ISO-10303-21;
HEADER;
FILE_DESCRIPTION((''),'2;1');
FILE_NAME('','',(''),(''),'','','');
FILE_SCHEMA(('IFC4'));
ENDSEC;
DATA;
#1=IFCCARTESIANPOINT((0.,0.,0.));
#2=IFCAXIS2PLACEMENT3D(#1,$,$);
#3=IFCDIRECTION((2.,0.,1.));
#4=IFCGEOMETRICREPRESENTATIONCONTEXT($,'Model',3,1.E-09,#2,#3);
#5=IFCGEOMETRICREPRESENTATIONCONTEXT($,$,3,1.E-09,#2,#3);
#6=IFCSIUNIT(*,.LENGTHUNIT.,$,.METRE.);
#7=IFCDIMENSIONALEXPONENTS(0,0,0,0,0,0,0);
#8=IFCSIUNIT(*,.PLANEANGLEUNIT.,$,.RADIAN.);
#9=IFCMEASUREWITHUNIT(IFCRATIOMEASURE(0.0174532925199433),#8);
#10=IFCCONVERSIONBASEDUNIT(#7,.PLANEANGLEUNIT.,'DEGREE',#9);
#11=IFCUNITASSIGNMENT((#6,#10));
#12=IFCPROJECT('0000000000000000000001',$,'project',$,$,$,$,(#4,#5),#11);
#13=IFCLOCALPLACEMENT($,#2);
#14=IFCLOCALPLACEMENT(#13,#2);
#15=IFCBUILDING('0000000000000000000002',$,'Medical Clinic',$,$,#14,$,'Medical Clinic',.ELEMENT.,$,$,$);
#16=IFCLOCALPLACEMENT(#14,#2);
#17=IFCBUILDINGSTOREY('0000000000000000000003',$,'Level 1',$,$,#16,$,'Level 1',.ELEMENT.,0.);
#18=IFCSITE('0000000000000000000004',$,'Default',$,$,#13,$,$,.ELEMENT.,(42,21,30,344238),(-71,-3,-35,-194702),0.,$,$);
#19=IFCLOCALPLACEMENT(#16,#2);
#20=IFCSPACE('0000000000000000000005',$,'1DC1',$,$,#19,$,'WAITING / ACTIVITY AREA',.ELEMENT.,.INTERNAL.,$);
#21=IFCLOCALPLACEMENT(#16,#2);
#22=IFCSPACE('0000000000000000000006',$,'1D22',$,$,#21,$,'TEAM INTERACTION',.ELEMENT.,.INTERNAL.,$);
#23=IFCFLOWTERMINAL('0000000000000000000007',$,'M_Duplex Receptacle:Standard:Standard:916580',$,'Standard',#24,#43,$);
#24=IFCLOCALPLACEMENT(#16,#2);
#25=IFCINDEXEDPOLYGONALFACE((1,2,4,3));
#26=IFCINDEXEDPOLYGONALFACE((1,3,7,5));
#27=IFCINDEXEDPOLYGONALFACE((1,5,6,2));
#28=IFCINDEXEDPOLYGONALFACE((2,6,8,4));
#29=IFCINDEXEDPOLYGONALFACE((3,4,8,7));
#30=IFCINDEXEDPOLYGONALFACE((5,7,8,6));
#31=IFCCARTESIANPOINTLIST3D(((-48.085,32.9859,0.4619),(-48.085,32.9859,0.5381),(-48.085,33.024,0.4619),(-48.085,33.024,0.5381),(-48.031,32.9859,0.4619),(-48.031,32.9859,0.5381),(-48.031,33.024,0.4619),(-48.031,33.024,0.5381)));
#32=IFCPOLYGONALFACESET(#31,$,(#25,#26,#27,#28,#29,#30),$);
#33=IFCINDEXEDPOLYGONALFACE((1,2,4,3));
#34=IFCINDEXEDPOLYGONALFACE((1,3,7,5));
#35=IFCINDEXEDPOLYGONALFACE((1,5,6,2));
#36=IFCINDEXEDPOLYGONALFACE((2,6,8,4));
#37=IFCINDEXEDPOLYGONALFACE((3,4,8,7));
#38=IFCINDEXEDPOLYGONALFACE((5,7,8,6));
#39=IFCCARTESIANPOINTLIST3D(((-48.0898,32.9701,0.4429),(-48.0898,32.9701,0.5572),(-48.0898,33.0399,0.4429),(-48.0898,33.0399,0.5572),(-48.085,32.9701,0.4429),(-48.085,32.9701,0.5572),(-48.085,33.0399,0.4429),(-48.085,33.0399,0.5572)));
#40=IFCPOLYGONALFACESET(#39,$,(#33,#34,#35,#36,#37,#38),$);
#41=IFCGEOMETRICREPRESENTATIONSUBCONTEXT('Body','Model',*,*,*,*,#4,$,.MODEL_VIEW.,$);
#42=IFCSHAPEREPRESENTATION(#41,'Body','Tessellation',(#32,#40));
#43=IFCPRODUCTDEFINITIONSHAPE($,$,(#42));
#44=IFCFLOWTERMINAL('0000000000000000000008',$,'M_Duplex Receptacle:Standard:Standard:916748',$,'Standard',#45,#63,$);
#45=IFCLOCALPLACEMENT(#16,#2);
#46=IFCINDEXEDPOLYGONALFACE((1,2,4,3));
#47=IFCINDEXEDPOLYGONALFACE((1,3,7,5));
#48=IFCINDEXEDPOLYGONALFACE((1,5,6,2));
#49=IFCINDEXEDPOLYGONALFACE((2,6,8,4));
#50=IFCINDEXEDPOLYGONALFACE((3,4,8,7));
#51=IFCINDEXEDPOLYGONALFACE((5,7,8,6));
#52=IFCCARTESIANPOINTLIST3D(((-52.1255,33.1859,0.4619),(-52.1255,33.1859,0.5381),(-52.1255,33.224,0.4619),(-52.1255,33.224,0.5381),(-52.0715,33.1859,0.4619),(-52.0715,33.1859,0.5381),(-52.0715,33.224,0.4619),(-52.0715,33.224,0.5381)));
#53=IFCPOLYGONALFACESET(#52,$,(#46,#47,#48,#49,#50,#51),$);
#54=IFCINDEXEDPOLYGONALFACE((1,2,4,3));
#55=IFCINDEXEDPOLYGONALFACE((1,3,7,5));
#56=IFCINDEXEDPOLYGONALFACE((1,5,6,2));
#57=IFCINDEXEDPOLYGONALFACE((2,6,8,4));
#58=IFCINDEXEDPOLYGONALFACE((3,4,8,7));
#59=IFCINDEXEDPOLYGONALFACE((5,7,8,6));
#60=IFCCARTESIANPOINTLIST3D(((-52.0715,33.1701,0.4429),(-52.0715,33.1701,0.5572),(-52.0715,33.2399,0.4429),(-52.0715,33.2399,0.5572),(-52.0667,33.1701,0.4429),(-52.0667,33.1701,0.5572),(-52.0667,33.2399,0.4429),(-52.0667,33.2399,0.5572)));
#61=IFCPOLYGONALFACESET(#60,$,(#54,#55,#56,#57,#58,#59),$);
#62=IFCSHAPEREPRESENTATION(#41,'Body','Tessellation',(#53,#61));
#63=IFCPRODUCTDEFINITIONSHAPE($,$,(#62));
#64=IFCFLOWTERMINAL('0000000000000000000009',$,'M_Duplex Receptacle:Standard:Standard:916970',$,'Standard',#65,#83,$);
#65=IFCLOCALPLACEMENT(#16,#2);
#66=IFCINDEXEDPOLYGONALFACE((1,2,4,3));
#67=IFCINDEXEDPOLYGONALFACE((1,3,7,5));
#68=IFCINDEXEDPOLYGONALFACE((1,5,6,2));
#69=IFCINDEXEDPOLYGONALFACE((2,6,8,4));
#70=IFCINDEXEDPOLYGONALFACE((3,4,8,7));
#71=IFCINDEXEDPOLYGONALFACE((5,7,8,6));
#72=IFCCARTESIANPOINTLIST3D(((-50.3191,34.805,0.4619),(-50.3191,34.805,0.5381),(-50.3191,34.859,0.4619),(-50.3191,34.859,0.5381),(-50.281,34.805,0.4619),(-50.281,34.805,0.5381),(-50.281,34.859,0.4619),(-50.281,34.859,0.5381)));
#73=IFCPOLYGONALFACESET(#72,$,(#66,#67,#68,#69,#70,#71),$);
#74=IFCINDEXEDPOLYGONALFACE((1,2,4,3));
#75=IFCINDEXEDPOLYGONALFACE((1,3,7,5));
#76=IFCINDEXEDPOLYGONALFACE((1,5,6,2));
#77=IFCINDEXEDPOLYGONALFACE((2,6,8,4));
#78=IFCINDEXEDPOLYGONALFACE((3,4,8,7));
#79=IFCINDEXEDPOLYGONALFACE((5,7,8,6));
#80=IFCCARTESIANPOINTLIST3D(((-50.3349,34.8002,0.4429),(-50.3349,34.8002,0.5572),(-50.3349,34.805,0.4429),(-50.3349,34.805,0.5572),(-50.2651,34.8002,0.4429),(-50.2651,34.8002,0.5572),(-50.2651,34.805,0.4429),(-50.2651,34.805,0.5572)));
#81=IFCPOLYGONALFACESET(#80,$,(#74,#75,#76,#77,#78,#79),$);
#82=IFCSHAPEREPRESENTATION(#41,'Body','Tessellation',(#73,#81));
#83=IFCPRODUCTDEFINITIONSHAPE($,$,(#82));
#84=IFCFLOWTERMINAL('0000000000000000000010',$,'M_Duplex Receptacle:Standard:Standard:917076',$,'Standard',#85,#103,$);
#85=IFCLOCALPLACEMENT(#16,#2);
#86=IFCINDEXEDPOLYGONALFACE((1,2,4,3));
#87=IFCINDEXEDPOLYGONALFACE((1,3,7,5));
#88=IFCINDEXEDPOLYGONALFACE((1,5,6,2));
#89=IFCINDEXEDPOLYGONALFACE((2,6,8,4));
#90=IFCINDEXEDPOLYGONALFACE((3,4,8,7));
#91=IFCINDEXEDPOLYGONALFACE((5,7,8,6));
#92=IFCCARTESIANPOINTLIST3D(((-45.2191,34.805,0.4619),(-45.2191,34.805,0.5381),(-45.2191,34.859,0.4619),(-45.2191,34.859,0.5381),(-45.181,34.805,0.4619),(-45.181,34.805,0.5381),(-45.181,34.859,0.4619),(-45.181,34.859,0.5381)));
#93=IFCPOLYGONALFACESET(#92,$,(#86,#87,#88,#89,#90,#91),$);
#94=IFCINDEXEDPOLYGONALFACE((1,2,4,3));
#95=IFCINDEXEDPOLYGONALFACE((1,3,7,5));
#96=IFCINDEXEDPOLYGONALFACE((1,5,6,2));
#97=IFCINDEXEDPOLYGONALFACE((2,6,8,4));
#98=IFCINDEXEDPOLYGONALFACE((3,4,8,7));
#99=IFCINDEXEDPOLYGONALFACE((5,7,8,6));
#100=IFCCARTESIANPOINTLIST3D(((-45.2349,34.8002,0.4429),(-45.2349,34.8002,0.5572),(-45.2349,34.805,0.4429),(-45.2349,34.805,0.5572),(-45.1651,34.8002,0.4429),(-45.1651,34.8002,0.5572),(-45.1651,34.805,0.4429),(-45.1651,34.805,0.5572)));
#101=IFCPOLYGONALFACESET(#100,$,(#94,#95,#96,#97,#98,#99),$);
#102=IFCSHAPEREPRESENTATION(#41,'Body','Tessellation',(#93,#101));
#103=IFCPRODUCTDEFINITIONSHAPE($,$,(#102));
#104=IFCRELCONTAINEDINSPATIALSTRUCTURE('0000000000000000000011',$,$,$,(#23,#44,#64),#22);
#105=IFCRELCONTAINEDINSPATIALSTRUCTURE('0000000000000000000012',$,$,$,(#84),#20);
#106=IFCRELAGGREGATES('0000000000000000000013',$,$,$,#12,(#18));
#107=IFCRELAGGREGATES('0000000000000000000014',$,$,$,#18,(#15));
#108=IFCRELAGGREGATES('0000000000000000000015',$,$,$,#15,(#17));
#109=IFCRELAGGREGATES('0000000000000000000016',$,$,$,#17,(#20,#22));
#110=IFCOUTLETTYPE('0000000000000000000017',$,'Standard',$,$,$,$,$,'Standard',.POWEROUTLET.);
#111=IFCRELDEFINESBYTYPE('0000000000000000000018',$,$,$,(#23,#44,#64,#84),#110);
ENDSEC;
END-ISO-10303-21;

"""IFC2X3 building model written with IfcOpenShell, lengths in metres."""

from ifc_helpers import new_model, entity, si_unit, converted_unit, direction, frame, frame_2d, origin, origin_2d_with_axis, place, context, subcontext, project, spatial, rectangle, extrude, source, transform, mapped, type_object, type_shapes, element, save


model = new_model("IFC2X3")

# Units and contexts
model_context = context("Model", 3, precision=1e-09, world=origin(), true_north=direction((2.0, 0.0, 1.0)))
context_of_model = context(None, 3, precision=1e-09, world=origin(), true_north=direction((2.0, 0.0, 1.0)))
body_context = subcontext(model_context, "Body", "Model", "MODEL_VIEW")
ifc_project = project(units=[si_unit("LENGTHUNIT", "METRE"), converted_unit("PLANEANGLEUNIT", "DEGREE", entity("IfcRatioMeasure", 0.0174532925199433), si_unit("PLANEANGLEUNIT", "RADIAN"), dimensions=[0, 0, 0, 0, 0, 0, 0])], contexts=[model_context, context_of_model])

# Site, building, storey, space
site_placement = place(None, origin())
site = spatial("IfcSite", under=ifc_project, at=site_placement, Name="Default", CompositionType="ELEMENT", RefLatitude=(42, 21, 30, 344238), RefLongitude=(-71, -3, -35, -194702), RefElevation=0.0)
building_placement = place(site_placement, origin())
building = spatial("IfcBuilding", under=site, at=building_placement, Name="Medical Clinic", LongName="Medical Clinic", CompositionType="ELEMENT")
storey_placement = place(building_placement, origin())
storey = spatial("IfcBuildingStorey", under=building, at=storey_placement, Name="Level 1", LongName="Level 1", CompositionType="ELEMENT", Elevation=0.0)
space_1_placement = place(storey_placement, origin())
space_1 = spatial("IfcSpace", under=storey, at=space_1_placement, Name="1DC1", LongName="WAITING / ACTIVITY AREA", CompositionType="ELEMENT", InteriorOrExteriorSpace="INTERNAL")

# Shared definitions
space_2_placement = place(storey_placement, origin())
space_2 = spatial("IfcSpace", under=storey, at=space_2_placement, Name="1D22", LongName="TEAM INTERACTION", CompositionType="ELEMENT", InteriorOrExteriorSpace="INTERNAL")

# Flow terminals
outlet_type = type_object("IfcOutletType", Name="Standard", ElementType="Standard", PredefinedType="POWEROUTLET")
shared_shape_1 = source(origin(), body_context, "Body", "SweptSolid", [
    extrude(rectangle(XDim=0.0381, YDim=0.0762, at=origin_2d_with_axis()), frame((0.0, 0.0, -0.054), z_axis=(0.0, 0.0, 1.0), x_axis=(-1.0, 0.0, 0.0)), (0.0, 0.0, 1.0), 0.054),
    extrude(rectangle(XDim=0.0698, YDim=0.1143, at=frame_2d((0.0, 0.0), x_axis=(1.0, 0.0))), frame((0.0, 0.0, 0.0), z_axis=(0.0, 0.0, 1.0), x_axis=(-1.0, 0.0, 0.0)), (0.0, 0.0, 1.0), 0.0048),
])
type_shapes(outlet_type, [shared_shape_1])
for number, where, z_axis, x_axis, name in (
    (1, (-48.085, 33.005, 0.5), (-1.0, 0.0, 0.0), (0.0, -1.0, 0.0), "M_Duplex Receptacle:Standard:Standard:916580"),
    (2, (-52.0715, 33.205, 0.5), (1.0, 0.0, 0.0), (0.0, 1.0, 0.0), "M_Duplex Receptacle:Standard:Standard:916748"),
    (3, (-50.3, 34.805, 0.5), (0.0, -1.0, 0.0), (1.0, 0.0, 0.0), "M_Duplex Receptacle:Standard:Standard:916970"),
):
    element("IfcFlowTerminal", number, at=place(space_2_placement, frame(where, z_axis=z_axis, x_axis=x_axis)), inside=space_2, type_object=outlet_type, Name=name, ObjectType="Standard", context=body_context, shape_type="MappedRepresentation", body=[
        mapped(shared_shape_1, transform((0.0, 0.0, 0.0), scale=1.0)),
    ])
flow_terminal_1_placement = place(space_1_placement, frame((-45.2, 34.805, 0.5), z_axis=(0.0, -1.0, 0.0), x_axis=(1.0, 0.0, 0.0)))
element("IfcFlowTerminal", 4, at=flow_terminal_1_placement, inside=space_1, type_object=outlet_type, Name="M_Duplex Receptacle:Standard:Standard:917076", ObjectType="Standard", context=body_context, shape_type="MappedRepresentation", body=[
    mapped(shared_shape_1, transform((0.0, 0.0, 0.0), scale=1.0)),
])

save(model, "model.ifc")
